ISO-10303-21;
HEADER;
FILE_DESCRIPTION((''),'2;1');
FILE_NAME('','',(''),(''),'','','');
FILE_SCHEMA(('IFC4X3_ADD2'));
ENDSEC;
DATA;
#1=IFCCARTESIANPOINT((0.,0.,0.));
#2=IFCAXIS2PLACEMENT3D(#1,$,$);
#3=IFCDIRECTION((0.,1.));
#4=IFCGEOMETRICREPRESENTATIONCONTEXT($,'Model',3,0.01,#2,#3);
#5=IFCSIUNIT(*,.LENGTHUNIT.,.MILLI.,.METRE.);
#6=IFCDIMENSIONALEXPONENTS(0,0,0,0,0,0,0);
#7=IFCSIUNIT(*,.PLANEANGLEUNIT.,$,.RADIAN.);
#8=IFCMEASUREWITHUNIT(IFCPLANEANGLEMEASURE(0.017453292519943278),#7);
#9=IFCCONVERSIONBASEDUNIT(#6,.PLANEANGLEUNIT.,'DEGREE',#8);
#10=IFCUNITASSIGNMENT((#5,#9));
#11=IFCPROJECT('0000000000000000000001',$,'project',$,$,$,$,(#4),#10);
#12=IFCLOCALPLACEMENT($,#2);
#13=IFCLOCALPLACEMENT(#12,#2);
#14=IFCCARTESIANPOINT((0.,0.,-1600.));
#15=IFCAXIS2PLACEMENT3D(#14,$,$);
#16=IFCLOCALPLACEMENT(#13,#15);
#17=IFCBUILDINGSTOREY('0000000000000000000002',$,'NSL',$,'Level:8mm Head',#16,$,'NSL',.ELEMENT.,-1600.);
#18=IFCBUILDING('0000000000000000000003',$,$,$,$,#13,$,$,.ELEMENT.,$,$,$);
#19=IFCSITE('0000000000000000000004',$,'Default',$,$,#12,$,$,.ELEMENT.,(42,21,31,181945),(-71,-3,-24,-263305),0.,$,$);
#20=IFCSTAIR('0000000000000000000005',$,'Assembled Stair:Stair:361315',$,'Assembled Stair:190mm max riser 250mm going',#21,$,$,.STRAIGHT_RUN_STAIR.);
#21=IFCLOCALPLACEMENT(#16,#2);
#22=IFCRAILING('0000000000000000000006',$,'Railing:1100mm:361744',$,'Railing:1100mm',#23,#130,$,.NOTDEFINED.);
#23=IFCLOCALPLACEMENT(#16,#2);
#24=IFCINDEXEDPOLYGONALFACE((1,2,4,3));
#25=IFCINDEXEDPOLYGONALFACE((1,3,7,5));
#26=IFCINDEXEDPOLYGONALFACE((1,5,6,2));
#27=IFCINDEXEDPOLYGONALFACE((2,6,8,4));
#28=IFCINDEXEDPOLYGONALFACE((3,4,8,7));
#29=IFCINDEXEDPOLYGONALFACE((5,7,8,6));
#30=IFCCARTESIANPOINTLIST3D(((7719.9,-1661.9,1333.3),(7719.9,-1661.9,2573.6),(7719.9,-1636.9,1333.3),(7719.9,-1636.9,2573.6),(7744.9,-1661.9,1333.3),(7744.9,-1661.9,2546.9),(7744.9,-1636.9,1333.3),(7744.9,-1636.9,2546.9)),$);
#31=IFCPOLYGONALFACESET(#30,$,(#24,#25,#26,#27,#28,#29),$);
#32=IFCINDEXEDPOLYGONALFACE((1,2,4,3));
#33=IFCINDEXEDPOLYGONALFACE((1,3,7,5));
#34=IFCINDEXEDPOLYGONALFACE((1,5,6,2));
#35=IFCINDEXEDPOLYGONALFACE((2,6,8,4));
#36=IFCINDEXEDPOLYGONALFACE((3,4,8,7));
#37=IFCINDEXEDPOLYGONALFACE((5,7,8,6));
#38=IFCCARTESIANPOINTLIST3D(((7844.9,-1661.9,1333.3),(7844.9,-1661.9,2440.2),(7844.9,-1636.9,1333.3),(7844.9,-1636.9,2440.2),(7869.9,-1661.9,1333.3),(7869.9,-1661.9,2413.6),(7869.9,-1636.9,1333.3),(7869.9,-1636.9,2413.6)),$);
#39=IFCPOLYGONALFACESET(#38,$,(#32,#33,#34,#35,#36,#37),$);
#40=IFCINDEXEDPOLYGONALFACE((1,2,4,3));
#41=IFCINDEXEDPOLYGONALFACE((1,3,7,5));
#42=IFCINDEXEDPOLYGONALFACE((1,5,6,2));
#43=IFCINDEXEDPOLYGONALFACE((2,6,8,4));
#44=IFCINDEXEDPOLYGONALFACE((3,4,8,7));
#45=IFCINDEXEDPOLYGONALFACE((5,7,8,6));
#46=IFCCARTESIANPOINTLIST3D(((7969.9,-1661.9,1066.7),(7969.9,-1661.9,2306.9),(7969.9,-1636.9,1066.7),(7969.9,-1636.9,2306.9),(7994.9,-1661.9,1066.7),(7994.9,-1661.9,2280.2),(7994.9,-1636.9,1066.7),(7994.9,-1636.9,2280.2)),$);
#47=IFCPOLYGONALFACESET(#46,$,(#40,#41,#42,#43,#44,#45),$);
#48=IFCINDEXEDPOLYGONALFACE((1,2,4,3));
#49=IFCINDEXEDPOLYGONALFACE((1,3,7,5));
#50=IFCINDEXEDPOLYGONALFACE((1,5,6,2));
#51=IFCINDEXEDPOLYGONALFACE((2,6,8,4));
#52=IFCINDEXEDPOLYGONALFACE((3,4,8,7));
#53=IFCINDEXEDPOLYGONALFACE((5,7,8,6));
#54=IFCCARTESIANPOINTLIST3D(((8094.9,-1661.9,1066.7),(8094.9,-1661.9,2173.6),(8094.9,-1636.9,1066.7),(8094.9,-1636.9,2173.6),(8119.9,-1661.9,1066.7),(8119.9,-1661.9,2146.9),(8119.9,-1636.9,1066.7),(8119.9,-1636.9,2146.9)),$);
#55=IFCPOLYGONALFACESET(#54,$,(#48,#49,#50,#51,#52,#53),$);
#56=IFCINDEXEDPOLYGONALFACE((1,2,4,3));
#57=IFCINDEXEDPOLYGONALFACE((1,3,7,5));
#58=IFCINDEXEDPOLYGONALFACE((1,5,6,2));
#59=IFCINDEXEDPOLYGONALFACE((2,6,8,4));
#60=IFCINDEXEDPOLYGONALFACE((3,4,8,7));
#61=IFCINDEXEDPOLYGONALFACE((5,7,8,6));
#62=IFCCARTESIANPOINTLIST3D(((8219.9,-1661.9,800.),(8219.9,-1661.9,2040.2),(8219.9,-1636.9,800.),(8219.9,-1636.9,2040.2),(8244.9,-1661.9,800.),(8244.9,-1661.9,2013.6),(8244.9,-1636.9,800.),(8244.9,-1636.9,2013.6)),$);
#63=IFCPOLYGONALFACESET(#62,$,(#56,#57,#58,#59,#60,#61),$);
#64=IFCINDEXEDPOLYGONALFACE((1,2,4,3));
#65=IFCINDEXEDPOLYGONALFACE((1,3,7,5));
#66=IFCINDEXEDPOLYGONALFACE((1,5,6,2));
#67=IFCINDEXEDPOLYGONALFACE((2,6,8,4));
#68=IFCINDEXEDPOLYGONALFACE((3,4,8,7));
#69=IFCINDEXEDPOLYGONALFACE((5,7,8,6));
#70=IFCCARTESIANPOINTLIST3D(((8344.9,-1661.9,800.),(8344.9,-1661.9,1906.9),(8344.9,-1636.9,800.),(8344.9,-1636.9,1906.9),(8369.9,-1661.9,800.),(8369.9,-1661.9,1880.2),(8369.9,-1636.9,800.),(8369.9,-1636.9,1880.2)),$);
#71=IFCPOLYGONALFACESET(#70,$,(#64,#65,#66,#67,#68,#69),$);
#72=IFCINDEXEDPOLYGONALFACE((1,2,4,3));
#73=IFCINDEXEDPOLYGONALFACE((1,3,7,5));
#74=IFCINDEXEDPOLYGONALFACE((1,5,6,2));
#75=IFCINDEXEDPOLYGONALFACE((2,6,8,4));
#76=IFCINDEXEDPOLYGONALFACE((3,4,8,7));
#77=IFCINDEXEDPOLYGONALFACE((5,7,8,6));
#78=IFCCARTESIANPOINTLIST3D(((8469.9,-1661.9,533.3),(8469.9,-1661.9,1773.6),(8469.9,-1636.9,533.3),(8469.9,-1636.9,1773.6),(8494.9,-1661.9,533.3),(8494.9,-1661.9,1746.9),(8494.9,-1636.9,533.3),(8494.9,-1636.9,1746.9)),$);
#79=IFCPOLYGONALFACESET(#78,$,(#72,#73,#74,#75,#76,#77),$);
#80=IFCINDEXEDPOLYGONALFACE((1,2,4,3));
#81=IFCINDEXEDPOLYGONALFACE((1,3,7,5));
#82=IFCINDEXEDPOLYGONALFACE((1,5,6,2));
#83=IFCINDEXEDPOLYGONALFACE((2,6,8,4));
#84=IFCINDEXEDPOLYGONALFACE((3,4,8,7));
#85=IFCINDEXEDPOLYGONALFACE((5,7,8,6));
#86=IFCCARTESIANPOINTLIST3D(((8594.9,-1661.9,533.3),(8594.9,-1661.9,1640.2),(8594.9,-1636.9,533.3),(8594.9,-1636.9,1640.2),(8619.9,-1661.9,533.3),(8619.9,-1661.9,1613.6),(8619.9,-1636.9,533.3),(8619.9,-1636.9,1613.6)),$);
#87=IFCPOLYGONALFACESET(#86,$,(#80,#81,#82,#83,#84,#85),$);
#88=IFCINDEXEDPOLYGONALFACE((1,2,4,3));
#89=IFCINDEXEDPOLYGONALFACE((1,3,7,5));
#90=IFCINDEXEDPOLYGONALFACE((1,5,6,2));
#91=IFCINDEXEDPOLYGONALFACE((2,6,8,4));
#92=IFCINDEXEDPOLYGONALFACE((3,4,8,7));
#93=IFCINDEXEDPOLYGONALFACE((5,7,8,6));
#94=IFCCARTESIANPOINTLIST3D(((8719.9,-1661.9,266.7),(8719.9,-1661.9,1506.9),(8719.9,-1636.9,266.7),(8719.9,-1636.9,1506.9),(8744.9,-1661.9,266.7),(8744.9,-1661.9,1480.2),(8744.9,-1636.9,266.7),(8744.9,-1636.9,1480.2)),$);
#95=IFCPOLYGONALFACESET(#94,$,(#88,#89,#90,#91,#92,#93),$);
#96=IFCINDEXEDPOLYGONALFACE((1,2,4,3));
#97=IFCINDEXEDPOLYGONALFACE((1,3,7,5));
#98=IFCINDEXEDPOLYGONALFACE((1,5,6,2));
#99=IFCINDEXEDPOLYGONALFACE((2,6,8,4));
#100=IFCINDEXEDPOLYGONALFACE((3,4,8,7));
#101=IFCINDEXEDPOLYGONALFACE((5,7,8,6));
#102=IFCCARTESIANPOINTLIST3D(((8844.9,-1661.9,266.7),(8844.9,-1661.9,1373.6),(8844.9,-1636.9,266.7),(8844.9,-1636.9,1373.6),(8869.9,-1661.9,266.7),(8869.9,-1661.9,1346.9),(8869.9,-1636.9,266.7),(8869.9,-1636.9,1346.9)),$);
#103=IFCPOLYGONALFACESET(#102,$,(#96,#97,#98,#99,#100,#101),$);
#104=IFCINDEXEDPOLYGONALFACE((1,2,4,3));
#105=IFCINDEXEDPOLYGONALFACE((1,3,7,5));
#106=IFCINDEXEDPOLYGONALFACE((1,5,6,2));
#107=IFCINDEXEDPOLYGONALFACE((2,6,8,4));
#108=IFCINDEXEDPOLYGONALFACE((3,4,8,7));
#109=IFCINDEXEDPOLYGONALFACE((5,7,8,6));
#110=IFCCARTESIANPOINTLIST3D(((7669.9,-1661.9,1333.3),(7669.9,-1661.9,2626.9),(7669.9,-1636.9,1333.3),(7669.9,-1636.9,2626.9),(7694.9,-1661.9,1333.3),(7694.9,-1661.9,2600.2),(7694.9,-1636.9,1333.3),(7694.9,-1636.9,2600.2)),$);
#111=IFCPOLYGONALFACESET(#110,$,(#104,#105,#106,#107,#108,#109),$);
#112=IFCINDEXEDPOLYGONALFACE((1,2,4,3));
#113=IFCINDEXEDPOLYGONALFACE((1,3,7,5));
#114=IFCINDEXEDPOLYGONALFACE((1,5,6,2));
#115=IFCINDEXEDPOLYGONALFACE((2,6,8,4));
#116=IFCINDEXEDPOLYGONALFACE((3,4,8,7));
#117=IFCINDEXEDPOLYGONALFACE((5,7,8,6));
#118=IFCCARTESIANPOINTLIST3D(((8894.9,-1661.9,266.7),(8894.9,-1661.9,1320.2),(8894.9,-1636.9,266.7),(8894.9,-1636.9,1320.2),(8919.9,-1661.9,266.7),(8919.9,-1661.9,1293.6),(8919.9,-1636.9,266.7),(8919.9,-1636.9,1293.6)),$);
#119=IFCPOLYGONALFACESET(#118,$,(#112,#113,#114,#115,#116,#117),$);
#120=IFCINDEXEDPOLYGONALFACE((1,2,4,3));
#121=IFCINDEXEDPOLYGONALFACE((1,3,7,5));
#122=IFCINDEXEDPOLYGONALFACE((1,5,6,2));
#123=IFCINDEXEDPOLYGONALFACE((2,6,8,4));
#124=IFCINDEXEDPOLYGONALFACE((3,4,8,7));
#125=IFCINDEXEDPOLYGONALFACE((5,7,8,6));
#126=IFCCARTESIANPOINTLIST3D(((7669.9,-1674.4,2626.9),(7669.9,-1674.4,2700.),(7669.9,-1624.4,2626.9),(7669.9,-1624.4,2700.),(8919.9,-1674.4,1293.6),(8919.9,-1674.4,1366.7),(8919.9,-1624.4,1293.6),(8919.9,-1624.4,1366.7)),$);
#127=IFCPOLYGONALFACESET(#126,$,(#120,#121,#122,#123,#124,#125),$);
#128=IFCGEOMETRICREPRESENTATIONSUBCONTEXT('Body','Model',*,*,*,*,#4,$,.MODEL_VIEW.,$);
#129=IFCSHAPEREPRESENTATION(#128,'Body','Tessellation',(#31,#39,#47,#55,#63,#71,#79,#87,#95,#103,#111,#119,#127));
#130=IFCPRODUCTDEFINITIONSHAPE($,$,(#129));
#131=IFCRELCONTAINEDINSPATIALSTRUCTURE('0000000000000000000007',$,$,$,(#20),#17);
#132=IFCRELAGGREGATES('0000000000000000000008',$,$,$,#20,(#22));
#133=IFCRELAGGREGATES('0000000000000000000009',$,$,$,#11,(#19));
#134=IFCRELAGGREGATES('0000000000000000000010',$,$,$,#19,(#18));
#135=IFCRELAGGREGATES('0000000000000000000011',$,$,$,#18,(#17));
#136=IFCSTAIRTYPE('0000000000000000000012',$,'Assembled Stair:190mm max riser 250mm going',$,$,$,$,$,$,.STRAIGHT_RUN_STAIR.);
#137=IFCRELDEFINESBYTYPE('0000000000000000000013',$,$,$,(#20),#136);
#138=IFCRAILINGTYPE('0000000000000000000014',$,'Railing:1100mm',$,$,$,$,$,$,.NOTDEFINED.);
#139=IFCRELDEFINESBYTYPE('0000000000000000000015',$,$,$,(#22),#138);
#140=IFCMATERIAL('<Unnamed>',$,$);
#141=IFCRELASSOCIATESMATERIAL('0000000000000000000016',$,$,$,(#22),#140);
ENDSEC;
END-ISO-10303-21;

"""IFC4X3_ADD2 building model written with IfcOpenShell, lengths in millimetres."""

from ifc_helpers import new_model, entity, si_unit, converted_unit, direction, frame, origin, place, context, subcontext, project, spatial, polyline, outline, extrude, material, type_object, element, aggregate, save


model = new_model("IFC4X3_ADD2")

# Units and contexts
model_context = context("Model", 3, precision=0.01, world=origin(), true_north=direction((0.0, 1.0)))
body_context = subcontext(model_context, "Body", "Model", "MODEL_VIEW")
ifc_project = project(units=[si_unit("LENGTHUNIT", "METRE", prefix="MILLI"), converted_unit("PLANEANGLEUNIT", "DEGREE", entity("IfcPlaneAngleMeasure", 0.017453292519943278), si_unit("PLANEANGLEUNIT", "RADIAN"), dimensions=[0, 0, 0, 0, 0, 0, 0])], contexts=[model_context])

# Site, building, storey
site_placement = place(None, origin())
site = spatial("IfcSite", under=ifc_project, at=site_placement, Name="Default", CompositionType="ELEMENT", RefLatitude=(42, 21, 31, 181945), RefLongitude=(-71, -3, -24, -263305), RefElevation=0.0)
building_placement = place(site_placement, origin())
building = spatial("IfcBuilding", under=site, at=building_placement, CompositionType="ELEMENT")
storey_placement = place(building_placement, frame((0.0, 0.0, -1600.0)))
storey = spatial("IfcBuildingStorey", under=building, at=storey_placement, Name="NSL", ObjectType="Level:8mm Head", LongName="NSL", CompositionType="ELEMENT", Elevation=-1600.0)

# Stair
stair_type = type_object("IfcStairType", Name="Assembled Stair:190mm max riser 250mm going", PredefinedType="STRAIGHT_RUN_STAIR")
stair_placement = place(storey_placement, origin())
stair = element("IfcStair", 1, at=stair_placement, inside=storey, type_object=stair_type, Name="Assembled Stair:Stair:361315", ObjectType="Assembled Stair:190mm max riser 250mm going", PredefinedType="STRAIGHT_RUN_STAIR")
ifc_material_1 = material(Name="<Unnamed>")

# Railing
railing_type = type_object("IfcRailingType", Name="Railing:1100mm", PredefinedType="NOTDEFINED")
railing_1_placement = place(stair_placement, frame((7669.9, -1674.4, 266.7)))
railing_1 = element("IfcRailing", 2, at=railing_1_placement, type_object=railing_type, material=ifc_material_1, Name="Railing:1100mm:361744", ObjectType="Railing:1100mm", PredefinedType="NOTDEFINED", context=body_context, shape_type="SweptSolid", body=[
    extrude(outline(polyline([(-12.5, -613.4), (12.5, -613.4), (12.5, 626.8), (-12.5, 600.1), (-12.5, -613.4)])), frame((62.5, 12.5, 1680.1), z_axis=(0.0, 1.0, 0.0), x_axis=(-1.0, 0.0, 0.0)), (0.0, 0.0, 1.0), 25.0),
    extrude(outline(polyline([(-12.5, -546.8), (12.5, -546.8), (12.5, 560.1), (-12.5, 533.4), (-12.5, -546.8)])), frame((187.5, 12.5, 1613.4), z_axis=(0.0, 1.0, 0.0), x_axis=(-1.0, 0.0, 0.0)), (0.0, 0.0, 1.0), 25.0),
    extrude(outline(polyline([(-12.5, -613.4), (12.5, -613.4), (12.5, 626.8), (-12.5, 600.1), (-12.5, -613.4)])), frame((312.5, 12.5, 1413.4), z_axis=(0.0, 1.0, 0.0), x_axis=(-1.0, 0.0, 0.0)), (0.0, 0.0, 1.0), 25.0),
    extrude(outline(polyline([(-12.5, -546.8), (12.5, -546.8), (12.5, 560.1), (-12.5, 533.4), (-12.5, -546.8)])), frame((437.5, 12.5, 1346.8), z_axis=(0.0, 1.0, 0.0), x_axis=(-1.0, 0.0, 0.0)), (0.0, 0.0, 1.0), 25.0),
    extrude(outline(polyline([(-12.5, -613.4), (12.5, -613.4), (12.5, 626.8), (-12.5, 600.1), (-12.5, -613.4)])), frame((562.5, 12.5, 1146.8), z_axis=(0.0, 1.0, 0.0), x_axis=(-1.0, 0.0, 0.0)), (0.0, 0.0, 1.0), 25.0),
    extrude(outline(polyline([(-12.5, -546.8), (12.5, -546.8), (12.5, 560.1), (-12.5, 533.4), (-12.5, -546.8)])), frame((687.5, 12.5, 1080.1), z_axis=(0.0, 1.0, 0.0), x_axis=(-1.0, 0.0, 0.0)), (0.0, 0.0, 1.0), 25.0),
    extrude(outline(polyline([(-12.5, -613.4), (12.5, -613.4), (12.5, 626.8), (-12.5, 600.1), (-12.5, -613.4)])), frame((812.5, 12.5, 880.1), z_axis=(0.0, 1.0, 0.0), x_axis=(-1.0, 0.0, 0.0)), (0.0, 0.0, 1.0), 25.0),
    extrude(outline(polyline([(-12.5, -546.8), (12.5, -546.8), (12.5, 560.1), (-12.5, 533.4), (-12.5, -546.8)])), frame((937.5, 12.5, 813.4), z_axis=(0.0, 1.0, 0.0), x_axis=(-1.0, 0.0, 0.0)), (0.0, 0.0, 1.0), 25.0),
    extrude(outline(polyline([(-12.5, -613.4), (12.5, -613.4), (12.5, 626.8), (-12.5, 600.1), (-12.5, -613.4)])), frame((1062.5, 12.5, 613.4), z_axis=(0.0, 1.0, 0.0), x_axis=(-1.0, 0.0, 0.0)), (0.0, 0.0, 1.0), 25.0),
    extrude(outline(polyline([(-12.5, -546.8), (12.5, -546.8), (12.5, 560.1), (-12.5, 533.4), (-12.5, -546.8)])), frame((1187.5, 12.5, 546.8), z_axis=(0.0, 1.0, 0.0), x_axis=(-1.0, 0.0, 0.0)), (0.0, 0.0, 1.0), 25.0),
    extrude(outline(polyline([(-12.5, -640.1), (12.5, -640.1), (12.5, 653.4), (-12.5, 626.8), (-12.5, -640.1)])), frame((12.5, 12.5, 1706.8), z_axis=(0.0, 1.0, 0.0), x_axis=(-1.0, 0.0, 0.0)), (0.0, 0.0, 1.0), 25.0),
    extrude(outline(polyline([(-12.5, -520.1), (12.5, -520.1), (12.5, 533.4), (-12.5, 506.8), (-12.5, -520.1)])), frame((1237.5, 12.5, 520.1), z_axis=(0.0, 1.0, 0.0), x_axis=(-1.0, 0.0, 0.0)), (0.0, 0.0, 1.0), 25.0),
    extrude(outline(polyline([(-940.5, -25.0), (887.2, -25.0), (940.5, 25.0), (-887.2, 25.0), (-940.5, -25.0)])), frame((625.0, 0.0, 1730.1), z_axis=(0.0, 1.0, 0.0), x_axis=(-0.683941, 0.0, 0.729537)), (0.0, 0.0, 1.0), 50.0),
])
aggregate(stair, [railing_1])

save(model, "model.ifc")
